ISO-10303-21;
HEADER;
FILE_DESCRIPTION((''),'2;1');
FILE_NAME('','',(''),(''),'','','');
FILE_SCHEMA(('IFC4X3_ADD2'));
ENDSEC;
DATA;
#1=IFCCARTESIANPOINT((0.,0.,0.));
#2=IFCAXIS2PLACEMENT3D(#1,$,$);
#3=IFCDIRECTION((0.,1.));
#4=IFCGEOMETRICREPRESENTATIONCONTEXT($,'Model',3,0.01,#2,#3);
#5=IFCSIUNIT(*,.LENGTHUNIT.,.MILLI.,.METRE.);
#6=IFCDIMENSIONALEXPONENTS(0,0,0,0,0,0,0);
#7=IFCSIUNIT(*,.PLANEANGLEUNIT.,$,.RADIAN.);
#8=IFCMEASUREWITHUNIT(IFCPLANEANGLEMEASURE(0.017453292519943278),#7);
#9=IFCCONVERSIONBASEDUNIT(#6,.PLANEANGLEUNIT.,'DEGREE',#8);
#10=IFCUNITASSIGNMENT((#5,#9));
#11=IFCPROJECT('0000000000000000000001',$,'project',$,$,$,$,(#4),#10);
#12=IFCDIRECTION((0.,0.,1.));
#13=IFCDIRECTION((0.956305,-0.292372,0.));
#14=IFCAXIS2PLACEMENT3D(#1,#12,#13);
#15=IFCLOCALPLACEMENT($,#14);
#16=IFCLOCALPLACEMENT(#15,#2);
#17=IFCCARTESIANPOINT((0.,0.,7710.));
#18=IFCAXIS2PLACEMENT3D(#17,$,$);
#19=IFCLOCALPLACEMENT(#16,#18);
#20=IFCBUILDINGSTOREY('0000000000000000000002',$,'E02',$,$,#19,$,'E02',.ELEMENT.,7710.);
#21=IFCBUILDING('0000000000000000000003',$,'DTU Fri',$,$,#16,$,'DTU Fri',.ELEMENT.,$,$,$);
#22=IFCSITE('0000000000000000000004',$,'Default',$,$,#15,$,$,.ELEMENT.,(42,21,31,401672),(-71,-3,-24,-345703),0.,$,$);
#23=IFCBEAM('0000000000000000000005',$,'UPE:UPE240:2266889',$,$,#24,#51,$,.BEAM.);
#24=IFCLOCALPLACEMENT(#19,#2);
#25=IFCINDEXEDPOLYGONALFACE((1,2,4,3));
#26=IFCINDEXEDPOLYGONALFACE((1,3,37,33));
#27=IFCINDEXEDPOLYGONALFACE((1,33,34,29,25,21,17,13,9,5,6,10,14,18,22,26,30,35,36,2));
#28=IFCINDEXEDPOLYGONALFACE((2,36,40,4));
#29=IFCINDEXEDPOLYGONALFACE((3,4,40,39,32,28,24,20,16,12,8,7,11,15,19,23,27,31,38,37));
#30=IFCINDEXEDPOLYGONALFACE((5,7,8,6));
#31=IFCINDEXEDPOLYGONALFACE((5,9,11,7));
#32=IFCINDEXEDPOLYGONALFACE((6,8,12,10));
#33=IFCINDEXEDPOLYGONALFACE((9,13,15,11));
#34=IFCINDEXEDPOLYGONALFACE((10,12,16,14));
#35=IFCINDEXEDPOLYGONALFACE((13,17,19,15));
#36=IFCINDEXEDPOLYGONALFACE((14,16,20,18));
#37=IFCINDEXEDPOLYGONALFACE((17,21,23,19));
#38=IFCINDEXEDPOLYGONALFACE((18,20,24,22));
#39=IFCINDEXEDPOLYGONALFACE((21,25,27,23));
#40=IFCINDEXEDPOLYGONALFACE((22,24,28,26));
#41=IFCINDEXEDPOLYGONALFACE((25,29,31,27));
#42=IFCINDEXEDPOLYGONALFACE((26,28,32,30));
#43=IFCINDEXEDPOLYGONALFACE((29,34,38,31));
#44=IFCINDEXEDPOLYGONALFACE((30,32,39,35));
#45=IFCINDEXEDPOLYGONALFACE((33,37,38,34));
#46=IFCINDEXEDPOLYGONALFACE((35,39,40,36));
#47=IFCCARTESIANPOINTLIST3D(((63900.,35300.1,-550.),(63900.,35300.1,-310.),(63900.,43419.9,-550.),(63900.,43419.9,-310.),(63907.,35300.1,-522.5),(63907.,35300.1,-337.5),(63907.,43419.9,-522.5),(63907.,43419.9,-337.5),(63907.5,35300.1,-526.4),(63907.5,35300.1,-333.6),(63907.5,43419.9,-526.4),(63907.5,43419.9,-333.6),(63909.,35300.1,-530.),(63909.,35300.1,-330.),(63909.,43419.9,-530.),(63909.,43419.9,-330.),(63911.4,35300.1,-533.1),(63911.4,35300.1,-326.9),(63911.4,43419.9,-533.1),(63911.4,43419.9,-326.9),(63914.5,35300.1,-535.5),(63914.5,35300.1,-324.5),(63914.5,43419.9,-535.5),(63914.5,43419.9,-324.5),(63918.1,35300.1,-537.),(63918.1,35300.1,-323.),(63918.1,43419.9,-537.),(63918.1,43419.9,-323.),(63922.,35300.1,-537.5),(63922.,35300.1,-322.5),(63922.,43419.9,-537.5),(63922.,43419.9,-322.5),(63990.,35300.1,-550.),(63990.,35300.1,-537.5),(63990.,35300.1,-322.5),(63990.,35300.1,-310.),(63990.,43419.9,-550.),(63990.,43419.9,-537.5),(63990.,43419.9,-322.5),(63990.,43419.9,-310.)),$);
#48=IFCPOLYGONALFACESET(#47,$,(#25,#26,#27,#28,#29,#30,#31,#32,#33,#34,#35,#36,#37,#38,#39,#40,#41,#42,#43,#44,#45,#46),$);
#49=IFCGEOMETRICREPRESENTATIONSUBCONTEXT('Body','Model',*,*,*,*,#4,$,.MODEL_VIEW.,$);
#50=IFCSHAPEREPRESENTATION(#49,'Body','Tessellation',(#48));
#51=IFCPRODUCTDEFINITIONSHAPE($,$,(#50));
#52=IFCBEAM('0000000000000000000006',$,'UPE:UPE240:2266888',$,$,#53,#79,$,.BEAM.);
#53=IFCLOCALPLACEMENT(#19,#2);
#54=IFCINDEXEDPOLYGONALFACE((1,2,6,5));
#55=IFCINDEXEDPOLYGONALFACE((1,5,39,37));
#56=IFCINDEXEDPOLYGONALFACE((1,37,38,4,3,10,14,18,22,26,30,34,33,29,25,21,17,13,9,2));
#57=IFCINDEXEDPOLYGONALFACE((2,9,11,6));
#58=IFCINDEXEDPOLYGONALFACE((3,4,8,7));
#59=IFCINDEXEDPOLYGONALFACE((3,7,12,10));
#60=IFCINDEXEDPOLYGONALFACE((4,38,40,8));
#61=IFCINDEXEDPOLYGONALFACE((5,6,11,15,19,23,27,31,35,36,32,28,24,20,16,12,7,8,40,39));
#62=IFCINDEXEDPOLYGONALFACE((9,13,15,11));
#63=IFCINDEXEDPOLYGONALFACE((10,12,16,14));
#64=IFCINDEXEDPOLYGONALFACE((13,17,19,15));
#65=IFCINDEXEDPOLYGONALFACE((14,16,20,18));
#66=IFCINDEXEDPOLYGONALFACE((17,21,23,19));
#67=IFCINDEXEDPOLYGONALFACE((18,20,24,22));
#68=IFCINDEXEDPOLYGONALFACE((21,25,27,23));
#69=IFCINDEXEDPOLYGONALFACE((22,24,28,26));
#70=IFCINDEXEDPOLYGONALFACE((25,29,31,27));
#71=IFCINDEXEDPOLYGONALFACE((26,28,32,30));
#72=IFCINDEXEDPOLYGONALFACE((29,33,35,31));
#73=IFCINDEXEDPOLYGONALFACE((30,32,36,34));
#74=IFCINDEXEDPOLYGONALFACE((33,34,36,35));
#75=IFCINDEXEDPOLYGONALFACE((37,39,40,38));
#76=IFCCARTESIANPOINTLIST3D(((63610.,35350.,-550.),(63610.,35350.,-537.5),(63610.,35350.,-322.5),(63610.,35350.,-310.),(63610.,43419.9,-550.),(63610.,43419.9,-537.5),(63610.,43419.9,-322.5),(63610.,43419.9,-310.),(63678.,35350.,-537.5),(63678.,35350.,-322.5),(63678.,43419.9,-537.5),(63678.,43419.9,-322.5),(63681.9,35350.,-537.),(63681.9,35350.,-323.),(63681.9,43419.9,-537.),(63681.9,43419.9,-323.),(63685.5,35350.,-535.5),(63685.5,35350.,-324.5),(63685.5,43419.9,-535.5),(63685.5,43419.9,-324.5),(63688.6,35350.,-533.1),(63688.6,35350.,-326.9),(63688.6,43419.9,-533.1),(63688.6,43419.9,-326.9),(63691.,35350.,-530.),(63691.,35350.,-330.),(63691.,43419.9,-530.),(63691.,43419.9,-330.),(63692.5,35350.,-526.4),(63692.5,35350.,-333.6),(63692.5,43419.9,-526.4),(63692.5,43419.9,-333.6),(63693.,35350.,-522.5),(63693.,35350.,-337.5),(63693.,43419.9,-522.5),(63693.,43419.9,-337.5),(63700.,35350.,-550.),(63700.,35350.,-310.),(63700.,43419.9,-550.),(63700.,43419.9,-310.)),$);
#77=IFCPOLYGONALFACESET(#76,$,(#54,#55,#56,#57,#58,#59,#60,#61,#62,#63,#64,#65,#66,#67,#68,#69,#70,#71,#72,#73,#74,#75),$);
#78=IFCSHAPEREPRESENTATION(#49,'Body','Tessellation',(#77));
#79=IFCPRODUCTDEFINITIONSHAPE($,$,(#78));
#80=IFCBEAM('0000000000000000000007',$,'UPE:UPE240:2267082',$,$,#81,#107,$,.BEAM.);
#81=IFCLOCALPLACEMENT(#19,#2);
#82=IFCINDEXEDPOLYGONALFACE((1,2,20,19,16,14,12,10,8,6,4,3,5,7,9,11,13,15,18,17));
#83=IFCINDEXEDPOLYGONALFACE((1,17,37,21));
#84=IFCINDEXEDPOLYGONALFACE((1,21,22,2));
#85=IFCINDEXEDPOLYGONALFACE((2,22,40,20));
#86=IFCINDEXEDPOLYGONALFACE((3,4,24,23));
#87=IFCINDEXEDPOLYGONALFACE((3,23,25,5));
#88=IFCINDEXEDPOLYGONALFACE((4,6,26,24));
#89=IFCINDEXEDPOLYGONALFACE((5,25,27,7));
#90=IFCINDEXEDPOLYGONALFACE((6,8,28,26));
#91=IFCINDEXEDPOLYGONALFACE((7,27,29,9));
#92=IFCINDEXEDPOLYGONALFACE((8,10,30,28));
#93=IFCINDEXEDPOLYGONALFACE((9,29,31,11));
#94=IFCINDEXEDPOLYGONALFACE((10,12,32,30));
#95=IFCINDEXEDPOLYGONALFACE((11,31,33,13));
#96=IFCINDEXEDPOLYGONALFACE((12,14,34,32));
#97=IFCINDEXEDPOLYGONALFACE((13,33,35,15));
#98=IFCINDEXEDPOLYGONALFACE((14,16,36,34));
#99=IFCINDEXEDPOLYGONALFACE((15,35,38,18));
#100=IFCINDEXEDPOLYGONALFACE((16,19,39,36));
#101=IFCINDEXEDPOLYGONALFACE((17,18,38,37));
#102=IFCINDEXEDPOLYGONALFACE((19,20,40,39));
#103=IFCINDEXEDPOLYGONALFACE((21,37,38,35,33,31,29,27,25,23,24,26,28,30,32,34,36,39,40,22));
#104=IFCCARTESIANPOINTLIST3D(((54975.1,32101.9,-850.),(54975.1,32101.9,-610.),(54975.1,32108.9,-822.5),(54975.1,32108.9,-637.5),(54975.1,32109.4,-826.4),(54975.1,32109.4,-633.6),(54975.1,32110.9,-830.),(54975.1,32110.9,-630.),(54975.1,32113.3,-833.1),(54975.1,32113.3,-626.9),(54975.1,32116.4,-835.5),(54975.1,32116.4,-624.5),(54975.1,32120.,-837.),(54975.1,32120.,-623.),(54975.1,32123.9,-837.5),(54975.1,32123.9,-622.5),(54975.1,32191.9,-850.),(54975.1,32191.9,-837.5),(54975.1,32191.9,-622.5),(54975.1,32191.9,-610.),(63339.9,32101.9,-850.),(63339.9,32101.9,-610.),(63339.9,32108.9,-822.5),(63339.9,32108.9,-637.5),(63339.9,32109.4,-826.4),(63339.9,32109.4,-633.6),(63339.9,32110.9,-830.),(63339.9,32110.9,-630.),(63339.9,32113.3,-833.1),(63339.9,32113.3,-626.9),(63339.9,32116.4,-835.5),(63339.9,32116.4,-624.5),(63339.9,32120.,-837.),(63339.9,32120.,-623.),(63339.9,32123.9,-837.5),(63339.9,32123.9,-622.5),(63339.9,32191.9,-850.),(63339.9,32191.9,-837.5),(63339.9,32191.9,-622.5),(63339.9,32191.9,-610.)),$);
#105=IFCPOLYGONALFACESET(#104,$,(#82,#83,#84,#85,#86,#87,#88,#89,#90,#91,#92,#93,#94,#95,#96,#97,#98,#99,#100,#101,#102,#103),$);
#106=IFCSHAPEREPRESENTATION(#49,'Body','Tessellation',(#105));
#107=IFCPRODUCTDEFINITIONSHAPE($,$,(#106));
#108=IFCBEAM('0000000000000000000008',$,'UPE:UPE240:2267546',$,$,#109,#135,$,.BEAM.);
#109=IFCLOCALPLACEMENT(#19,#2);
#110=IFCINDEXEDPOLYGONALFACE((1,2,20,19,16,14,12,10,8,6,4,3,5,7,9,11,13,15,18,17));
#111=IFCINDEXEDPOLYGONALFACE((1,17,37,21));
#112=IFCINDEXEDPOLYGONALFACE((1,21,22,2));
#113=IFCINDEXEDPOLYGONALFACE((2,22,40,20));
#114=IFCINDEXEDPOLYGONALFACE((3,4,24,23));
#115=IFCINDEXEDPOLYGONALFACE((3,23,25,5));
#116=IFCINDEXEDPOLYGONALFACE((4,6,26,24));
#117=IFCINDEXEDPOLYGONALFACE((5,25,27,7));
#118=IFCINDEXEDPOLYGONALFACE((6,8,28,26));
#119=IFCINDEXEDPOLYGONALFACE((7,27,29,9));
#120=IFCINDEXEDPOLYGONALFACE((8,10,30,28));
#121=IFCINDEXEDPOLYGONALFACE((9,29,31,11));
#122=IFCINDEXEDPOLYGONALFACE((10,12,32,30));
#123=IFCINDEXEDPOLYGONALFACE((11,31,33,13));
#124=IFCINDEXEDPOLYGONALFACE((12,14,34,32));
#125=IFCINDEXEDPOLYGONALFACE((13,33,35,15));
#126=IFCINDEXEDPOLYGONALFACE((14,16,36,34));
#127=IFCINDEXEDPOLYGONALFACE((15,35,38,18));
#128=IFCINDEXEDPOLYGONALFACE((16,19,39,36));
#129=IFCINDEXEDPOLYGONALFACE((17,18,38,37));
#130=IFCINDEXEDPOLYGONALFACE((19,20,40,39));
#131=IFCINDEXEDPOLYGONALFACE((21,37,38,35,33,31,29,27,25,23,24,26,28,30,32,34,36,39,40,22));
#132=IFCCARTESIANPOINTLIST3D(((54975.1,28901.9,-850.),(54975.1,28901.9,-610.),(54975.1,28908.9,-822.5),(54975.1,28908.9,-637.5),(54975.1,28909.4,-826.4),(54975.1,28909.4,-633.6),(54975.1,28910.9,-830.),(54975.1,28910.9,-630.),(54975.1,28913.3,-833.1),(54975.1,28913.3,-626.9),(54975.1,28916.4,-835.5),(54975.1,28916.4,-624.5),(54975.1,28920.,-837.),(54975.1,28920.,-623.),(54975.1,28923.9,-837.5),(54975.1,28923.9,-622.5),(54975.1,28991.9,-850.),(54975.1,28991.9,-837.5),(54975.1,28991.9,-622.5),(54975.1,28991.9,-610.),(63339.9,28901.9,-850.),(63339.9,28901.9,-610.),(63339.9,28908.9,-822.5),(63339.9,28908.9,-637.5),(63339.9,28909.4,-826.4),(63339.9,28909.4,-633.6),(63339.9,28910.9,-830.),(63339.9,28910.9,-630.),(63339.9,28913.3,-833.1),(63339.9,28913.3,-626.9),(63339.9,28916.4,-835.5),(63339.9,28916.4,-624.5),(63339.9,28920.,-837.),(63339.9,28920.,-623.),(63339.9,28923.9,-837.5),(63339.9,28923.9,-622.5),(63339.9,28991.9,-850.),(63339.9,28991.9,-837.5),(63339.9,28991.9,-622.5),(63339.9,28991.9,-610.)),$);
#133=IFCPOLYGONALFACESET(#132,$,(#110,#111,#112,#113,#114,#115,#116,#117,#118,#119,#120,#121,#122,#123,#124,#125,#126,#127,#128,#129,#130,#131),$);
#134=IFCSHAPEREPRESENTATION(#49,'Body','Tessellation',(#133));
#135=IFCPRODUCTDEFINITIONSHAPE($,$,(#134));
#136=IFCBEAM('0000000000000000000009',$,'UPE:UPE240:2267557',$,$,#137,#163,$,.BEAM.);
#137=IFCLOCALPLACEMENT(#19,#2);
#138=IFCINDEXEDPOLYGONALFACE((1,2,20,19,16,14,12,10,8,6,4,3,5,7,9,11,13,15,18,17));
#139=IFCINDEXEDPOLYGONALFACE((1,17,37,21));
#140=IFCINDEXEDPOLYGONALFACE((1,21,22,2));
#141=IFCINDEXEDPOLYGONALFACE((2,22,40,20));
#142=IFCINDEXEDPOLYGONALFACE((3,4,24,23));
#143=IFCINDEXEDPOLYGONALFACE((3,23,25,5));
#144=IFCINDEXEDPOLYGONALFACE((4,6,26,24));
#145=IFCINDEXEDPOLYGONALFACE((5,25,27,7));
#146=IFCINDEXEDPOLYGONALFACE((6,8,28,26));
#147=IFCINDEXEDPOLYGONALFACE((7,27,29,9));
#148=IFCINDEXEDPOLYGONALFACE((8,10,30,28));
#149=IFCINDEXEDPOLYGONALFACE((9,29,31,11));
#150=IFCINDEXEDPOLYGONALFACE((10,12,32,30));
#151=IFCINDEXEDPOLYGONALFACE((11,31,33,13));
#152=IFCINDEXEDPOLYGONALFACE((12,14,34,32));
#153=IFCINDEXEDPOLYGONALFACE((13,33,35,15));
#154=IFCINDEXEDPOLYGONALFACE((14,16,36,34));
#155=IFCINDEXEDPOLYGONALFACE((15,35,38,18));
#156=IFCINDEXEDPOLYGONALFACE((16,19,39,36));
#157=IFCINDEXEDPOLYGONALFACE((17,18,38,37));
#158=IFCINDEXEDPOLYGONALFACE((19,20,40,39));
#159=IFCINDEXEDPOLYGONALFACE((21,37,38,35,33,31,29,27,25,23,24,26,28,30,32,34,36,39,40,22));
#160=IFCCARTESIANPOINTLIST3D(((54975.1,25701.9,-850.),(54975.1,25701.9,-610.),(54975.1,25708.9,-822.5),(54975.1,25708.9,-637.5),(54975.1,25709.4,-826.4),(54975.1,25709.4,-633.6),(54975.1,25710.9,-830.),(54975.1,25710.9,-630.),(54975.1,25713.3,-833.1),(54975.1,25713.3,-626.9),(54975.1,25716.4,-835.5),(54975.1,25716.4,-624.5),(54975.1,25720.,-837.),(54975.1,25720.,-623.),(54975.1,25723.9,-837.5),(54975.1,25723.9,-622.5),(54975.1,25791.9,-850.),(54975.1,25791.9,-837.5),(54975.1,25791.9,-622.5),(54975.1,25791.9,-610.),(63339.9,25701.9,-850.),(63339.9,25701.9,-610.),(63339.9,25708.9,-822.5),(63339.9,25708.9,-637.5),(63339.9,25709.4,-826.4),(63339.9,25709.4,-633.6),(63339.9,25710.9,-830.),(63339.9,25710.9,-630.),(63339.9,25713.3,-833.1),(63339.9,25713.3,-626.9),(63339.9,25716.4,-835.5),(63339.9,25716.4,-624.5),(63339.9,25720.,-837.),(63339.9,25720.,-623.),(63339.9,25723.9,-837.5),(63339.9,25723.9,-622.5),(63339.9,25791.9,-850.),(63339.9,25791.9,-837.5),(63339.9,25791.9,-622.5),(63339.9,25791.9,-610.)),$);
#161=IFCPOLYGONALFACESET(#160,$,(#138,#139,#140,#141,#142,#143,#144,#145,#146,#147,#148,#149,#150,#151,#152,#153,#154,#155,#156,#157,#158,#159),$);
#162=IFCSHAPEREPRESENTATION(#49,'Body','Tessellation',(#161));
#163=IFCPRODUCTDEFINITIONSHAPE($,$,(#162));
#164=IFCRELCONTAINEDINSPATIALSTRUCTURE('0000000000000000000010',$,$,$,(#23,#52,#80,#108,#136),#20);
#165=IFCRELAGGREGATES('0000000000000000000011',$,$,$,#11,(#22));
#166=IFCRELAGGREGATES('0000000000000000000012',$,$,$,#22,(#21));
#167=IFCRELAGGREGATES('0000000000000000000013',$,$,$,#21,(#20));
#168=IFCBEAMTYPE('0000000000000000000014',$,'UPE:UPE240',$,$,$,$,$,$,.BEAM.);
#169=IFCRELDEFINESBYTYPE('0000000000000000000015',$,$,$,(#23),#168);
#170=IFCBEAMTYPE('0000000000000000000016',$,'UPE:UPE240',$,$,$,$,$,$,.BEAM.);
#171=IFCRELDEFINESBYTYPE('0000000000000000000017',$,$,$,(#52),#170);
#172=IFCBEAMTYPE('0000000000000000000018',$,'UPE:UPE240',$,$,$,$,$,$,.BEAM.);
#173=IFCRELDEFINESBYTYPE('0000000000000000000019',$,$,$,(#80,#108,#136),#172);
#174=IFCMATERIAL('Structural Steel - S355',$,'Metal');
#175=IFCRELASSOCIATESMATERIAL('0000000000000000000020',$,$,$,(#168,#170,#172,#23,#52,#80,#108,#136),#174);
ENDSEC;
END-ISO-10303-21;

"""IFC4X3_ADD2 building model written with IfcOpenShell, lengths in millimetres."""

from ifc_helpers import new_model, entity, si_unit, converted_unit, direction, frame, frame_2d, origin, place, context, subcontext, project, spatial, polyline, circle_curve, parameter, trimmed, segment, composite_curve, outline, extrude, source, transform, mapped, material, material_profile, profile_set, profile_usage, type_object, type_shapes, element, save


model = new_model("IFC4X3_ADD2")

# Units and contexts
model_context = context("Model", 3, precision=0.01, world=origin(), true_north=direction((0.0, 1.0)))
body_context = subcontext(model_context, "Body", "Model", "MODEL_VIEW")
ifc_project = project(units=[si_unit("LENGTHUNIT", "METRE", prefix="MILLI"), converted_unit("PLANEANGLEUNIT", "DEGREE", entity("IfcPlaneAngleMeasure", 0.017453292519943278), si_unit("PLANEANGLEUNIT", "RADIAN"), dimensions=[0, 0, 0, 0, 0, 0, 0])], contexts=[model_context])

# Site, building, storey
site_placement = place(None, frame((0.0, 0.0, 0.0), z_axis=(0.0, 0.0, 1.0), x_axis=(0.956305, -0.292372, 0.0)))
site = spatial("IfcSite", under=ifc_project, at=site_placement, Name="Default", CompositionType="ELEMENT", RefLatitude=(42, 21, 31, 401672), RefLongitude=(-71, -3, -24, -345703), RefElevation=0.0)
building_placement = place(site_placement, origin())
building = spatial("IfcBuilding", under=site, at=building_placement, Name="DTU Fri", LongName="DTU Fri", CompositionType="ELEMENT")
storey_placement = place(building_placement, frame((0.0, 0.0, 7710.0)))
storey = spatial("IfcBuildingStorey", under=building, at=storey_placement, Name="E02", LongName="E02", CompositionType="ELEMENT", Elevation=7710.0)

# Beams
ifc_material_1 = material(Name="Structural Steel - S355", Category="Metal")
ifc_material_profile_1 = material_profile(ifc_material_1, outline(composite_curve([segment(polyline([(-120.0, -48.2), (-107.5, -48.2)]), True, "CONTINUOUS"), segment(polyline([(-107.5, -48.2), (-107.5, 19.8)]), True, "CONTINUOUS"), segment(trimmed(circle_curve(frame_2d((-92.5, 19.8), x_axis=(-1.0, 0.0)), 15.0), [parameter(270.0)], [parameter(0.0)], True, "PARAMETER"), False, "CONTINUOUS"), segment(polyline([(-92.5, 34.8), (92.5, 34.8)]), True, "CONTINUOUS"), segment(trimmed(circle_curve(frame_2d((92.5, 19.8), x_axis=(0.0, 1.0)), 15.0), [parameter(270.0)], [parameter(0.0)], True, "PARAMETER"), False, "CONTINUOUS"), segment(polyline([(107.5, 19.8), (107.5, -48.2)]), True, "CONTINUOUS"), segment(polyline([(107.5, -48.2), (120.0, -48.2)]), True, "CONTINUOUS"), segment(polyline([(120.0, -48.2), (120.0, 41.8)]), True, "CONTINUOUS"), segment(polyline([(120.0, 41.8), (-120.0, 41.8)]), True, "CONTINUOUS"), segment(polyline([(-120.0, 41.8), (-120.0, -48.2)]), True, "CONTINUOUS")], self_intersect=False)), Name="UPE240")
ifc_profile_set_1 = profile_set([ifc_material_profile_1], Name="UPE240")
ifc_profile_usage_1 = profile_usage(ifc_profile_set_1, cardinal=8)
beam_type_1 = type_object("IfcBeamType", Name="UPE:UPE240", PredefinedType="BEAM", material=ifc_profile_set_1)
shared_shape_1 = source(origin(), body_context, "Body", "SweptSolid", [
    extrude(outline(composite_curve([segment(polyline([(-120.0, -48.2), (-107.5, -48.2)]), True, "CONTINUOUS"), segment(polyline([(-107.5, -48.2), (-107.5, 19.8)]), True, "CONTINUOUS"), segment(trimmed(circle_curve(frame_2d((-92.5, 19.8), x_axis=(-1.0, 0.0)), 15.0), [parameter(270.0)], [parameter(0.0)], True, "PARAMETER"), False, "CONTINUOUS"), segment(polyline([(-92.5, 34.8), (92.5, 34.8)]), True, "CONTINUOUS"), segment(trimmed(circle_curve(frame_2d((92.5, 19.8), x_axis=(0.0, 1.0)), 15.0), [parameter(270.0)], [parameter(0.0)], True, "PARAMETER"), False, "CONTINUOUS"), segment(polyline([(107.5, 19.8), (107.5, -48.2)]), True, "CONTINUOUS"), segment(polyline([(107.5, -48.2), (120.0, -48.2)]), True, "CONTINUOUS"), segment(polyline([(120.0, -48.2), (120.0, 41.8)]), True, "CONTINUOUS"), segment(polyline([(120.0, 41.8), (-120.0, 41.8)]), True, "CONTINUOUS"), segment(polyline([(-120.0, 41.8), (-120.0, -48.2)]), True, "CONTINUOUS")], self_intersect=False)), frame((-4059.9, -13.9, 0.0), z_axis=(1.0, 0.0, 0.0), x_axis=(0.0, 0.0, -1.0)), (0.0, 0.0, 1.0), 8119.8),
])
type_shapes(beam_type_1, [shared_shape_1])
beam_1_placement = place(storey_placement, frame((63927.9, 39360.0, -430.0), z_axis=(0.0, 0.0, 1.0), x_axis=(0.0, 1.0, 0.0)))
element("IfcBeam", 1, at=beam_1_placement, inside=storey, type_object=beam_type_1, material=ifc_profile_usage_1, Name="UPE:UPE240:2266889", PredefinedType="BEAM", context=body_context, shape_type="MappedRepresentation", body=[
    mapped(shared_shape_1, transform((0.0, 0.0, 0.0), scale=1.0)),
])
beam_type_2 = type_object("IfcBeamType", Name="UPE:UPE240", PredefinedType="BEAM", material=ifc_profile_set_1)
shared_shape_2 = source(origin(), body_context, "Body", "SweptSolid", [
    extrude(outline(composite_curve([segment(polyline([(-120.0, -48.2), (-107.5, -48.2)]), True, "CONTINUOUS"), segment(polyline([(-107.5, -48.2), (-107.5, 19.8)]), True, "CONTINUOUS"), segment(trimmed(circle_curve(frame_2d((-92.5, 19.8), x_axis=(-1.0, 0.0)), 15.0), [parameter(270.0)], [parameter(0.0)], True, "PARAMETER"), False, "CONTINUOUS"), segment(polyline([(-92.5, 34.8), (92.5, 34.8)]), True, "CONTINUOUS"), segment(trimmed(circle_curve(frame_2d((92.5, 19.8), x_axis=(0.0, 1.0)), 15.0), [parameter(270.0)], [parameter(0.0)], True, "PARAMETER"), False, "CONTINUOUS"), segment(polyline([(107.5, 19.8), (107.5, -48.2)]), True, "CONTINUOUS"), segment(polyline([(107.5, -48.2), (120.0, -48.2)]), True, "CONTINUOUS"), segment(polyline([(120.0, -48.2), (120.0, 41.8)]), True, "CONTINUOUS"), segment(polyline([(120.0, 41.8), (-120.0, 41.8)]), True, "CONTINUOUS"), segment(polyline([(-120.0, 41.8), (-120.0, -48.2)]), True, "CONTINUOUS")], self_intersect=False)), frame((-4034.9, -13.9, 0.0), z_axis=(1.0, 0.0, 0.0), x_axis=(0.0, 0.0, -1.0)), (0.0, 0.0, 1.0), 8069.9),
])
type_shapes(beam_type_2, [shared_shape_2])
beam_2_placement = place(storey_placement, frame((63672.1, 39385.0, -430.0), z_axis=(0.0, 0.0, 1.0), x_axis=(0.0, -1.0, 0.0)))
element("IfcBeam", 2, at=beam_2_placement, inside=storey, type_object=beam_type_2, material=ifc_profile_usage_1, Name="UPE:UPE240:2266888", PredefinedType="BEAM", context=body_context, shape_type="MappedRepresentation", body=[
    mapped(shared_shape_2, transform((0.0, 0.0, 0.0), scale=1.0)),
])
beam_type_3 = type_object("IfcBeamType", Name="UPE:UPE240", PredefinedType="BEAM", material=ifc_profile_set_1)
shared_shape_3 = source(origin(), body_context, "Body", "SweptSolid", [
    extrude(outline(composite_curve([segment(polyline([(-120.0, -48.2), (-107.5, -48.2)]), True, "CONTINUOUS"), segment(polyline([(-107.5, -48.2), (-107.5, 19.8)]), True, "CONTINUOUS"), segment(trimmed(circle_curve(frame_2d((-92.5, 19.8), x_axis=(-1.0, 0.0)), 15.0), [parameter(270.0)], [parameter(0.0)], True, "PARAMETER"), False, "CONTINUOUS"), segment(polyline([(-92.5, 34.8), (92.5, 34.8)]), True, "CONTINUOUS"), segment(trimmed(circle_curve(frame_2d((92.5, 19.8), x_axis=(0.0, 1.0)), 15.0), [parameter(270.0)], [parameter(0.0)], True, "PARAMETER"), False, "CONTINUOUS"), segment(polyline([(107.5, 19.8), (107.5, -48.2)]), True, "CONTINUOUS"), segment(polyline([(107.5, -48.2), (120.0, -48.2)]), True, "CONTINUOUS"), segment(polyline([(120.0, -48.2), (120.0, 41.8)]), True, "CONTINUOUS"), segment(polyline([(120.0, 41.8), (-120.0, 41.8)]), True, "CONTINUOUS"), segment(polyline([(-120.0, 41.8), (-120.0, -48.2)]), True, "CONTINUOUS")], self_intersect=False)), frame((-4182.4, -13.9, 0.0), z_axis=(1.0, 0.0, 0.0), x_axis=(0.0, 0.0, -1.0)), (0.0, 0.0, 1.0), 8364.8),
])
type_shapes(beam_type_3, [shared_shape_3])
for number, where, z_axis, x_axis, name in (
    (3, (59157.5, 32129.8, -730.0), (0.0, 0.0, 1.0), (-1.0, 0.0, 0.0), "UPE:UPE240:2267082"),
    (4, (59157.5, 28929.8, -730.0), (0.0, 0.0, 1.0), (-1.0, 0.0, 0.0), "UPE:UPE240:2267546"),
    (5, (59157.5, 25729.8, -730.0), (0.0, 0.0, 1.0), (-1.0, 0.0, 0.0), "UPE:UPE240:2267557"),
):
    element("IfcBeam", number, at=place(storey_placement, frame(where, z_axis=z_axis, x_axis=x_axis)), inside=storey, type_object=beam_type_3, material=ifc_profile_usage_1, Name=name, PredefinedType="BEAM", context=body_context, shape_type="MappedRepresentation", body=[
        mapped(shared_shape_3, transform((0.0, 0.0, 0.0), scale=1.0)),
    ])

save(model, "model.ifc")
